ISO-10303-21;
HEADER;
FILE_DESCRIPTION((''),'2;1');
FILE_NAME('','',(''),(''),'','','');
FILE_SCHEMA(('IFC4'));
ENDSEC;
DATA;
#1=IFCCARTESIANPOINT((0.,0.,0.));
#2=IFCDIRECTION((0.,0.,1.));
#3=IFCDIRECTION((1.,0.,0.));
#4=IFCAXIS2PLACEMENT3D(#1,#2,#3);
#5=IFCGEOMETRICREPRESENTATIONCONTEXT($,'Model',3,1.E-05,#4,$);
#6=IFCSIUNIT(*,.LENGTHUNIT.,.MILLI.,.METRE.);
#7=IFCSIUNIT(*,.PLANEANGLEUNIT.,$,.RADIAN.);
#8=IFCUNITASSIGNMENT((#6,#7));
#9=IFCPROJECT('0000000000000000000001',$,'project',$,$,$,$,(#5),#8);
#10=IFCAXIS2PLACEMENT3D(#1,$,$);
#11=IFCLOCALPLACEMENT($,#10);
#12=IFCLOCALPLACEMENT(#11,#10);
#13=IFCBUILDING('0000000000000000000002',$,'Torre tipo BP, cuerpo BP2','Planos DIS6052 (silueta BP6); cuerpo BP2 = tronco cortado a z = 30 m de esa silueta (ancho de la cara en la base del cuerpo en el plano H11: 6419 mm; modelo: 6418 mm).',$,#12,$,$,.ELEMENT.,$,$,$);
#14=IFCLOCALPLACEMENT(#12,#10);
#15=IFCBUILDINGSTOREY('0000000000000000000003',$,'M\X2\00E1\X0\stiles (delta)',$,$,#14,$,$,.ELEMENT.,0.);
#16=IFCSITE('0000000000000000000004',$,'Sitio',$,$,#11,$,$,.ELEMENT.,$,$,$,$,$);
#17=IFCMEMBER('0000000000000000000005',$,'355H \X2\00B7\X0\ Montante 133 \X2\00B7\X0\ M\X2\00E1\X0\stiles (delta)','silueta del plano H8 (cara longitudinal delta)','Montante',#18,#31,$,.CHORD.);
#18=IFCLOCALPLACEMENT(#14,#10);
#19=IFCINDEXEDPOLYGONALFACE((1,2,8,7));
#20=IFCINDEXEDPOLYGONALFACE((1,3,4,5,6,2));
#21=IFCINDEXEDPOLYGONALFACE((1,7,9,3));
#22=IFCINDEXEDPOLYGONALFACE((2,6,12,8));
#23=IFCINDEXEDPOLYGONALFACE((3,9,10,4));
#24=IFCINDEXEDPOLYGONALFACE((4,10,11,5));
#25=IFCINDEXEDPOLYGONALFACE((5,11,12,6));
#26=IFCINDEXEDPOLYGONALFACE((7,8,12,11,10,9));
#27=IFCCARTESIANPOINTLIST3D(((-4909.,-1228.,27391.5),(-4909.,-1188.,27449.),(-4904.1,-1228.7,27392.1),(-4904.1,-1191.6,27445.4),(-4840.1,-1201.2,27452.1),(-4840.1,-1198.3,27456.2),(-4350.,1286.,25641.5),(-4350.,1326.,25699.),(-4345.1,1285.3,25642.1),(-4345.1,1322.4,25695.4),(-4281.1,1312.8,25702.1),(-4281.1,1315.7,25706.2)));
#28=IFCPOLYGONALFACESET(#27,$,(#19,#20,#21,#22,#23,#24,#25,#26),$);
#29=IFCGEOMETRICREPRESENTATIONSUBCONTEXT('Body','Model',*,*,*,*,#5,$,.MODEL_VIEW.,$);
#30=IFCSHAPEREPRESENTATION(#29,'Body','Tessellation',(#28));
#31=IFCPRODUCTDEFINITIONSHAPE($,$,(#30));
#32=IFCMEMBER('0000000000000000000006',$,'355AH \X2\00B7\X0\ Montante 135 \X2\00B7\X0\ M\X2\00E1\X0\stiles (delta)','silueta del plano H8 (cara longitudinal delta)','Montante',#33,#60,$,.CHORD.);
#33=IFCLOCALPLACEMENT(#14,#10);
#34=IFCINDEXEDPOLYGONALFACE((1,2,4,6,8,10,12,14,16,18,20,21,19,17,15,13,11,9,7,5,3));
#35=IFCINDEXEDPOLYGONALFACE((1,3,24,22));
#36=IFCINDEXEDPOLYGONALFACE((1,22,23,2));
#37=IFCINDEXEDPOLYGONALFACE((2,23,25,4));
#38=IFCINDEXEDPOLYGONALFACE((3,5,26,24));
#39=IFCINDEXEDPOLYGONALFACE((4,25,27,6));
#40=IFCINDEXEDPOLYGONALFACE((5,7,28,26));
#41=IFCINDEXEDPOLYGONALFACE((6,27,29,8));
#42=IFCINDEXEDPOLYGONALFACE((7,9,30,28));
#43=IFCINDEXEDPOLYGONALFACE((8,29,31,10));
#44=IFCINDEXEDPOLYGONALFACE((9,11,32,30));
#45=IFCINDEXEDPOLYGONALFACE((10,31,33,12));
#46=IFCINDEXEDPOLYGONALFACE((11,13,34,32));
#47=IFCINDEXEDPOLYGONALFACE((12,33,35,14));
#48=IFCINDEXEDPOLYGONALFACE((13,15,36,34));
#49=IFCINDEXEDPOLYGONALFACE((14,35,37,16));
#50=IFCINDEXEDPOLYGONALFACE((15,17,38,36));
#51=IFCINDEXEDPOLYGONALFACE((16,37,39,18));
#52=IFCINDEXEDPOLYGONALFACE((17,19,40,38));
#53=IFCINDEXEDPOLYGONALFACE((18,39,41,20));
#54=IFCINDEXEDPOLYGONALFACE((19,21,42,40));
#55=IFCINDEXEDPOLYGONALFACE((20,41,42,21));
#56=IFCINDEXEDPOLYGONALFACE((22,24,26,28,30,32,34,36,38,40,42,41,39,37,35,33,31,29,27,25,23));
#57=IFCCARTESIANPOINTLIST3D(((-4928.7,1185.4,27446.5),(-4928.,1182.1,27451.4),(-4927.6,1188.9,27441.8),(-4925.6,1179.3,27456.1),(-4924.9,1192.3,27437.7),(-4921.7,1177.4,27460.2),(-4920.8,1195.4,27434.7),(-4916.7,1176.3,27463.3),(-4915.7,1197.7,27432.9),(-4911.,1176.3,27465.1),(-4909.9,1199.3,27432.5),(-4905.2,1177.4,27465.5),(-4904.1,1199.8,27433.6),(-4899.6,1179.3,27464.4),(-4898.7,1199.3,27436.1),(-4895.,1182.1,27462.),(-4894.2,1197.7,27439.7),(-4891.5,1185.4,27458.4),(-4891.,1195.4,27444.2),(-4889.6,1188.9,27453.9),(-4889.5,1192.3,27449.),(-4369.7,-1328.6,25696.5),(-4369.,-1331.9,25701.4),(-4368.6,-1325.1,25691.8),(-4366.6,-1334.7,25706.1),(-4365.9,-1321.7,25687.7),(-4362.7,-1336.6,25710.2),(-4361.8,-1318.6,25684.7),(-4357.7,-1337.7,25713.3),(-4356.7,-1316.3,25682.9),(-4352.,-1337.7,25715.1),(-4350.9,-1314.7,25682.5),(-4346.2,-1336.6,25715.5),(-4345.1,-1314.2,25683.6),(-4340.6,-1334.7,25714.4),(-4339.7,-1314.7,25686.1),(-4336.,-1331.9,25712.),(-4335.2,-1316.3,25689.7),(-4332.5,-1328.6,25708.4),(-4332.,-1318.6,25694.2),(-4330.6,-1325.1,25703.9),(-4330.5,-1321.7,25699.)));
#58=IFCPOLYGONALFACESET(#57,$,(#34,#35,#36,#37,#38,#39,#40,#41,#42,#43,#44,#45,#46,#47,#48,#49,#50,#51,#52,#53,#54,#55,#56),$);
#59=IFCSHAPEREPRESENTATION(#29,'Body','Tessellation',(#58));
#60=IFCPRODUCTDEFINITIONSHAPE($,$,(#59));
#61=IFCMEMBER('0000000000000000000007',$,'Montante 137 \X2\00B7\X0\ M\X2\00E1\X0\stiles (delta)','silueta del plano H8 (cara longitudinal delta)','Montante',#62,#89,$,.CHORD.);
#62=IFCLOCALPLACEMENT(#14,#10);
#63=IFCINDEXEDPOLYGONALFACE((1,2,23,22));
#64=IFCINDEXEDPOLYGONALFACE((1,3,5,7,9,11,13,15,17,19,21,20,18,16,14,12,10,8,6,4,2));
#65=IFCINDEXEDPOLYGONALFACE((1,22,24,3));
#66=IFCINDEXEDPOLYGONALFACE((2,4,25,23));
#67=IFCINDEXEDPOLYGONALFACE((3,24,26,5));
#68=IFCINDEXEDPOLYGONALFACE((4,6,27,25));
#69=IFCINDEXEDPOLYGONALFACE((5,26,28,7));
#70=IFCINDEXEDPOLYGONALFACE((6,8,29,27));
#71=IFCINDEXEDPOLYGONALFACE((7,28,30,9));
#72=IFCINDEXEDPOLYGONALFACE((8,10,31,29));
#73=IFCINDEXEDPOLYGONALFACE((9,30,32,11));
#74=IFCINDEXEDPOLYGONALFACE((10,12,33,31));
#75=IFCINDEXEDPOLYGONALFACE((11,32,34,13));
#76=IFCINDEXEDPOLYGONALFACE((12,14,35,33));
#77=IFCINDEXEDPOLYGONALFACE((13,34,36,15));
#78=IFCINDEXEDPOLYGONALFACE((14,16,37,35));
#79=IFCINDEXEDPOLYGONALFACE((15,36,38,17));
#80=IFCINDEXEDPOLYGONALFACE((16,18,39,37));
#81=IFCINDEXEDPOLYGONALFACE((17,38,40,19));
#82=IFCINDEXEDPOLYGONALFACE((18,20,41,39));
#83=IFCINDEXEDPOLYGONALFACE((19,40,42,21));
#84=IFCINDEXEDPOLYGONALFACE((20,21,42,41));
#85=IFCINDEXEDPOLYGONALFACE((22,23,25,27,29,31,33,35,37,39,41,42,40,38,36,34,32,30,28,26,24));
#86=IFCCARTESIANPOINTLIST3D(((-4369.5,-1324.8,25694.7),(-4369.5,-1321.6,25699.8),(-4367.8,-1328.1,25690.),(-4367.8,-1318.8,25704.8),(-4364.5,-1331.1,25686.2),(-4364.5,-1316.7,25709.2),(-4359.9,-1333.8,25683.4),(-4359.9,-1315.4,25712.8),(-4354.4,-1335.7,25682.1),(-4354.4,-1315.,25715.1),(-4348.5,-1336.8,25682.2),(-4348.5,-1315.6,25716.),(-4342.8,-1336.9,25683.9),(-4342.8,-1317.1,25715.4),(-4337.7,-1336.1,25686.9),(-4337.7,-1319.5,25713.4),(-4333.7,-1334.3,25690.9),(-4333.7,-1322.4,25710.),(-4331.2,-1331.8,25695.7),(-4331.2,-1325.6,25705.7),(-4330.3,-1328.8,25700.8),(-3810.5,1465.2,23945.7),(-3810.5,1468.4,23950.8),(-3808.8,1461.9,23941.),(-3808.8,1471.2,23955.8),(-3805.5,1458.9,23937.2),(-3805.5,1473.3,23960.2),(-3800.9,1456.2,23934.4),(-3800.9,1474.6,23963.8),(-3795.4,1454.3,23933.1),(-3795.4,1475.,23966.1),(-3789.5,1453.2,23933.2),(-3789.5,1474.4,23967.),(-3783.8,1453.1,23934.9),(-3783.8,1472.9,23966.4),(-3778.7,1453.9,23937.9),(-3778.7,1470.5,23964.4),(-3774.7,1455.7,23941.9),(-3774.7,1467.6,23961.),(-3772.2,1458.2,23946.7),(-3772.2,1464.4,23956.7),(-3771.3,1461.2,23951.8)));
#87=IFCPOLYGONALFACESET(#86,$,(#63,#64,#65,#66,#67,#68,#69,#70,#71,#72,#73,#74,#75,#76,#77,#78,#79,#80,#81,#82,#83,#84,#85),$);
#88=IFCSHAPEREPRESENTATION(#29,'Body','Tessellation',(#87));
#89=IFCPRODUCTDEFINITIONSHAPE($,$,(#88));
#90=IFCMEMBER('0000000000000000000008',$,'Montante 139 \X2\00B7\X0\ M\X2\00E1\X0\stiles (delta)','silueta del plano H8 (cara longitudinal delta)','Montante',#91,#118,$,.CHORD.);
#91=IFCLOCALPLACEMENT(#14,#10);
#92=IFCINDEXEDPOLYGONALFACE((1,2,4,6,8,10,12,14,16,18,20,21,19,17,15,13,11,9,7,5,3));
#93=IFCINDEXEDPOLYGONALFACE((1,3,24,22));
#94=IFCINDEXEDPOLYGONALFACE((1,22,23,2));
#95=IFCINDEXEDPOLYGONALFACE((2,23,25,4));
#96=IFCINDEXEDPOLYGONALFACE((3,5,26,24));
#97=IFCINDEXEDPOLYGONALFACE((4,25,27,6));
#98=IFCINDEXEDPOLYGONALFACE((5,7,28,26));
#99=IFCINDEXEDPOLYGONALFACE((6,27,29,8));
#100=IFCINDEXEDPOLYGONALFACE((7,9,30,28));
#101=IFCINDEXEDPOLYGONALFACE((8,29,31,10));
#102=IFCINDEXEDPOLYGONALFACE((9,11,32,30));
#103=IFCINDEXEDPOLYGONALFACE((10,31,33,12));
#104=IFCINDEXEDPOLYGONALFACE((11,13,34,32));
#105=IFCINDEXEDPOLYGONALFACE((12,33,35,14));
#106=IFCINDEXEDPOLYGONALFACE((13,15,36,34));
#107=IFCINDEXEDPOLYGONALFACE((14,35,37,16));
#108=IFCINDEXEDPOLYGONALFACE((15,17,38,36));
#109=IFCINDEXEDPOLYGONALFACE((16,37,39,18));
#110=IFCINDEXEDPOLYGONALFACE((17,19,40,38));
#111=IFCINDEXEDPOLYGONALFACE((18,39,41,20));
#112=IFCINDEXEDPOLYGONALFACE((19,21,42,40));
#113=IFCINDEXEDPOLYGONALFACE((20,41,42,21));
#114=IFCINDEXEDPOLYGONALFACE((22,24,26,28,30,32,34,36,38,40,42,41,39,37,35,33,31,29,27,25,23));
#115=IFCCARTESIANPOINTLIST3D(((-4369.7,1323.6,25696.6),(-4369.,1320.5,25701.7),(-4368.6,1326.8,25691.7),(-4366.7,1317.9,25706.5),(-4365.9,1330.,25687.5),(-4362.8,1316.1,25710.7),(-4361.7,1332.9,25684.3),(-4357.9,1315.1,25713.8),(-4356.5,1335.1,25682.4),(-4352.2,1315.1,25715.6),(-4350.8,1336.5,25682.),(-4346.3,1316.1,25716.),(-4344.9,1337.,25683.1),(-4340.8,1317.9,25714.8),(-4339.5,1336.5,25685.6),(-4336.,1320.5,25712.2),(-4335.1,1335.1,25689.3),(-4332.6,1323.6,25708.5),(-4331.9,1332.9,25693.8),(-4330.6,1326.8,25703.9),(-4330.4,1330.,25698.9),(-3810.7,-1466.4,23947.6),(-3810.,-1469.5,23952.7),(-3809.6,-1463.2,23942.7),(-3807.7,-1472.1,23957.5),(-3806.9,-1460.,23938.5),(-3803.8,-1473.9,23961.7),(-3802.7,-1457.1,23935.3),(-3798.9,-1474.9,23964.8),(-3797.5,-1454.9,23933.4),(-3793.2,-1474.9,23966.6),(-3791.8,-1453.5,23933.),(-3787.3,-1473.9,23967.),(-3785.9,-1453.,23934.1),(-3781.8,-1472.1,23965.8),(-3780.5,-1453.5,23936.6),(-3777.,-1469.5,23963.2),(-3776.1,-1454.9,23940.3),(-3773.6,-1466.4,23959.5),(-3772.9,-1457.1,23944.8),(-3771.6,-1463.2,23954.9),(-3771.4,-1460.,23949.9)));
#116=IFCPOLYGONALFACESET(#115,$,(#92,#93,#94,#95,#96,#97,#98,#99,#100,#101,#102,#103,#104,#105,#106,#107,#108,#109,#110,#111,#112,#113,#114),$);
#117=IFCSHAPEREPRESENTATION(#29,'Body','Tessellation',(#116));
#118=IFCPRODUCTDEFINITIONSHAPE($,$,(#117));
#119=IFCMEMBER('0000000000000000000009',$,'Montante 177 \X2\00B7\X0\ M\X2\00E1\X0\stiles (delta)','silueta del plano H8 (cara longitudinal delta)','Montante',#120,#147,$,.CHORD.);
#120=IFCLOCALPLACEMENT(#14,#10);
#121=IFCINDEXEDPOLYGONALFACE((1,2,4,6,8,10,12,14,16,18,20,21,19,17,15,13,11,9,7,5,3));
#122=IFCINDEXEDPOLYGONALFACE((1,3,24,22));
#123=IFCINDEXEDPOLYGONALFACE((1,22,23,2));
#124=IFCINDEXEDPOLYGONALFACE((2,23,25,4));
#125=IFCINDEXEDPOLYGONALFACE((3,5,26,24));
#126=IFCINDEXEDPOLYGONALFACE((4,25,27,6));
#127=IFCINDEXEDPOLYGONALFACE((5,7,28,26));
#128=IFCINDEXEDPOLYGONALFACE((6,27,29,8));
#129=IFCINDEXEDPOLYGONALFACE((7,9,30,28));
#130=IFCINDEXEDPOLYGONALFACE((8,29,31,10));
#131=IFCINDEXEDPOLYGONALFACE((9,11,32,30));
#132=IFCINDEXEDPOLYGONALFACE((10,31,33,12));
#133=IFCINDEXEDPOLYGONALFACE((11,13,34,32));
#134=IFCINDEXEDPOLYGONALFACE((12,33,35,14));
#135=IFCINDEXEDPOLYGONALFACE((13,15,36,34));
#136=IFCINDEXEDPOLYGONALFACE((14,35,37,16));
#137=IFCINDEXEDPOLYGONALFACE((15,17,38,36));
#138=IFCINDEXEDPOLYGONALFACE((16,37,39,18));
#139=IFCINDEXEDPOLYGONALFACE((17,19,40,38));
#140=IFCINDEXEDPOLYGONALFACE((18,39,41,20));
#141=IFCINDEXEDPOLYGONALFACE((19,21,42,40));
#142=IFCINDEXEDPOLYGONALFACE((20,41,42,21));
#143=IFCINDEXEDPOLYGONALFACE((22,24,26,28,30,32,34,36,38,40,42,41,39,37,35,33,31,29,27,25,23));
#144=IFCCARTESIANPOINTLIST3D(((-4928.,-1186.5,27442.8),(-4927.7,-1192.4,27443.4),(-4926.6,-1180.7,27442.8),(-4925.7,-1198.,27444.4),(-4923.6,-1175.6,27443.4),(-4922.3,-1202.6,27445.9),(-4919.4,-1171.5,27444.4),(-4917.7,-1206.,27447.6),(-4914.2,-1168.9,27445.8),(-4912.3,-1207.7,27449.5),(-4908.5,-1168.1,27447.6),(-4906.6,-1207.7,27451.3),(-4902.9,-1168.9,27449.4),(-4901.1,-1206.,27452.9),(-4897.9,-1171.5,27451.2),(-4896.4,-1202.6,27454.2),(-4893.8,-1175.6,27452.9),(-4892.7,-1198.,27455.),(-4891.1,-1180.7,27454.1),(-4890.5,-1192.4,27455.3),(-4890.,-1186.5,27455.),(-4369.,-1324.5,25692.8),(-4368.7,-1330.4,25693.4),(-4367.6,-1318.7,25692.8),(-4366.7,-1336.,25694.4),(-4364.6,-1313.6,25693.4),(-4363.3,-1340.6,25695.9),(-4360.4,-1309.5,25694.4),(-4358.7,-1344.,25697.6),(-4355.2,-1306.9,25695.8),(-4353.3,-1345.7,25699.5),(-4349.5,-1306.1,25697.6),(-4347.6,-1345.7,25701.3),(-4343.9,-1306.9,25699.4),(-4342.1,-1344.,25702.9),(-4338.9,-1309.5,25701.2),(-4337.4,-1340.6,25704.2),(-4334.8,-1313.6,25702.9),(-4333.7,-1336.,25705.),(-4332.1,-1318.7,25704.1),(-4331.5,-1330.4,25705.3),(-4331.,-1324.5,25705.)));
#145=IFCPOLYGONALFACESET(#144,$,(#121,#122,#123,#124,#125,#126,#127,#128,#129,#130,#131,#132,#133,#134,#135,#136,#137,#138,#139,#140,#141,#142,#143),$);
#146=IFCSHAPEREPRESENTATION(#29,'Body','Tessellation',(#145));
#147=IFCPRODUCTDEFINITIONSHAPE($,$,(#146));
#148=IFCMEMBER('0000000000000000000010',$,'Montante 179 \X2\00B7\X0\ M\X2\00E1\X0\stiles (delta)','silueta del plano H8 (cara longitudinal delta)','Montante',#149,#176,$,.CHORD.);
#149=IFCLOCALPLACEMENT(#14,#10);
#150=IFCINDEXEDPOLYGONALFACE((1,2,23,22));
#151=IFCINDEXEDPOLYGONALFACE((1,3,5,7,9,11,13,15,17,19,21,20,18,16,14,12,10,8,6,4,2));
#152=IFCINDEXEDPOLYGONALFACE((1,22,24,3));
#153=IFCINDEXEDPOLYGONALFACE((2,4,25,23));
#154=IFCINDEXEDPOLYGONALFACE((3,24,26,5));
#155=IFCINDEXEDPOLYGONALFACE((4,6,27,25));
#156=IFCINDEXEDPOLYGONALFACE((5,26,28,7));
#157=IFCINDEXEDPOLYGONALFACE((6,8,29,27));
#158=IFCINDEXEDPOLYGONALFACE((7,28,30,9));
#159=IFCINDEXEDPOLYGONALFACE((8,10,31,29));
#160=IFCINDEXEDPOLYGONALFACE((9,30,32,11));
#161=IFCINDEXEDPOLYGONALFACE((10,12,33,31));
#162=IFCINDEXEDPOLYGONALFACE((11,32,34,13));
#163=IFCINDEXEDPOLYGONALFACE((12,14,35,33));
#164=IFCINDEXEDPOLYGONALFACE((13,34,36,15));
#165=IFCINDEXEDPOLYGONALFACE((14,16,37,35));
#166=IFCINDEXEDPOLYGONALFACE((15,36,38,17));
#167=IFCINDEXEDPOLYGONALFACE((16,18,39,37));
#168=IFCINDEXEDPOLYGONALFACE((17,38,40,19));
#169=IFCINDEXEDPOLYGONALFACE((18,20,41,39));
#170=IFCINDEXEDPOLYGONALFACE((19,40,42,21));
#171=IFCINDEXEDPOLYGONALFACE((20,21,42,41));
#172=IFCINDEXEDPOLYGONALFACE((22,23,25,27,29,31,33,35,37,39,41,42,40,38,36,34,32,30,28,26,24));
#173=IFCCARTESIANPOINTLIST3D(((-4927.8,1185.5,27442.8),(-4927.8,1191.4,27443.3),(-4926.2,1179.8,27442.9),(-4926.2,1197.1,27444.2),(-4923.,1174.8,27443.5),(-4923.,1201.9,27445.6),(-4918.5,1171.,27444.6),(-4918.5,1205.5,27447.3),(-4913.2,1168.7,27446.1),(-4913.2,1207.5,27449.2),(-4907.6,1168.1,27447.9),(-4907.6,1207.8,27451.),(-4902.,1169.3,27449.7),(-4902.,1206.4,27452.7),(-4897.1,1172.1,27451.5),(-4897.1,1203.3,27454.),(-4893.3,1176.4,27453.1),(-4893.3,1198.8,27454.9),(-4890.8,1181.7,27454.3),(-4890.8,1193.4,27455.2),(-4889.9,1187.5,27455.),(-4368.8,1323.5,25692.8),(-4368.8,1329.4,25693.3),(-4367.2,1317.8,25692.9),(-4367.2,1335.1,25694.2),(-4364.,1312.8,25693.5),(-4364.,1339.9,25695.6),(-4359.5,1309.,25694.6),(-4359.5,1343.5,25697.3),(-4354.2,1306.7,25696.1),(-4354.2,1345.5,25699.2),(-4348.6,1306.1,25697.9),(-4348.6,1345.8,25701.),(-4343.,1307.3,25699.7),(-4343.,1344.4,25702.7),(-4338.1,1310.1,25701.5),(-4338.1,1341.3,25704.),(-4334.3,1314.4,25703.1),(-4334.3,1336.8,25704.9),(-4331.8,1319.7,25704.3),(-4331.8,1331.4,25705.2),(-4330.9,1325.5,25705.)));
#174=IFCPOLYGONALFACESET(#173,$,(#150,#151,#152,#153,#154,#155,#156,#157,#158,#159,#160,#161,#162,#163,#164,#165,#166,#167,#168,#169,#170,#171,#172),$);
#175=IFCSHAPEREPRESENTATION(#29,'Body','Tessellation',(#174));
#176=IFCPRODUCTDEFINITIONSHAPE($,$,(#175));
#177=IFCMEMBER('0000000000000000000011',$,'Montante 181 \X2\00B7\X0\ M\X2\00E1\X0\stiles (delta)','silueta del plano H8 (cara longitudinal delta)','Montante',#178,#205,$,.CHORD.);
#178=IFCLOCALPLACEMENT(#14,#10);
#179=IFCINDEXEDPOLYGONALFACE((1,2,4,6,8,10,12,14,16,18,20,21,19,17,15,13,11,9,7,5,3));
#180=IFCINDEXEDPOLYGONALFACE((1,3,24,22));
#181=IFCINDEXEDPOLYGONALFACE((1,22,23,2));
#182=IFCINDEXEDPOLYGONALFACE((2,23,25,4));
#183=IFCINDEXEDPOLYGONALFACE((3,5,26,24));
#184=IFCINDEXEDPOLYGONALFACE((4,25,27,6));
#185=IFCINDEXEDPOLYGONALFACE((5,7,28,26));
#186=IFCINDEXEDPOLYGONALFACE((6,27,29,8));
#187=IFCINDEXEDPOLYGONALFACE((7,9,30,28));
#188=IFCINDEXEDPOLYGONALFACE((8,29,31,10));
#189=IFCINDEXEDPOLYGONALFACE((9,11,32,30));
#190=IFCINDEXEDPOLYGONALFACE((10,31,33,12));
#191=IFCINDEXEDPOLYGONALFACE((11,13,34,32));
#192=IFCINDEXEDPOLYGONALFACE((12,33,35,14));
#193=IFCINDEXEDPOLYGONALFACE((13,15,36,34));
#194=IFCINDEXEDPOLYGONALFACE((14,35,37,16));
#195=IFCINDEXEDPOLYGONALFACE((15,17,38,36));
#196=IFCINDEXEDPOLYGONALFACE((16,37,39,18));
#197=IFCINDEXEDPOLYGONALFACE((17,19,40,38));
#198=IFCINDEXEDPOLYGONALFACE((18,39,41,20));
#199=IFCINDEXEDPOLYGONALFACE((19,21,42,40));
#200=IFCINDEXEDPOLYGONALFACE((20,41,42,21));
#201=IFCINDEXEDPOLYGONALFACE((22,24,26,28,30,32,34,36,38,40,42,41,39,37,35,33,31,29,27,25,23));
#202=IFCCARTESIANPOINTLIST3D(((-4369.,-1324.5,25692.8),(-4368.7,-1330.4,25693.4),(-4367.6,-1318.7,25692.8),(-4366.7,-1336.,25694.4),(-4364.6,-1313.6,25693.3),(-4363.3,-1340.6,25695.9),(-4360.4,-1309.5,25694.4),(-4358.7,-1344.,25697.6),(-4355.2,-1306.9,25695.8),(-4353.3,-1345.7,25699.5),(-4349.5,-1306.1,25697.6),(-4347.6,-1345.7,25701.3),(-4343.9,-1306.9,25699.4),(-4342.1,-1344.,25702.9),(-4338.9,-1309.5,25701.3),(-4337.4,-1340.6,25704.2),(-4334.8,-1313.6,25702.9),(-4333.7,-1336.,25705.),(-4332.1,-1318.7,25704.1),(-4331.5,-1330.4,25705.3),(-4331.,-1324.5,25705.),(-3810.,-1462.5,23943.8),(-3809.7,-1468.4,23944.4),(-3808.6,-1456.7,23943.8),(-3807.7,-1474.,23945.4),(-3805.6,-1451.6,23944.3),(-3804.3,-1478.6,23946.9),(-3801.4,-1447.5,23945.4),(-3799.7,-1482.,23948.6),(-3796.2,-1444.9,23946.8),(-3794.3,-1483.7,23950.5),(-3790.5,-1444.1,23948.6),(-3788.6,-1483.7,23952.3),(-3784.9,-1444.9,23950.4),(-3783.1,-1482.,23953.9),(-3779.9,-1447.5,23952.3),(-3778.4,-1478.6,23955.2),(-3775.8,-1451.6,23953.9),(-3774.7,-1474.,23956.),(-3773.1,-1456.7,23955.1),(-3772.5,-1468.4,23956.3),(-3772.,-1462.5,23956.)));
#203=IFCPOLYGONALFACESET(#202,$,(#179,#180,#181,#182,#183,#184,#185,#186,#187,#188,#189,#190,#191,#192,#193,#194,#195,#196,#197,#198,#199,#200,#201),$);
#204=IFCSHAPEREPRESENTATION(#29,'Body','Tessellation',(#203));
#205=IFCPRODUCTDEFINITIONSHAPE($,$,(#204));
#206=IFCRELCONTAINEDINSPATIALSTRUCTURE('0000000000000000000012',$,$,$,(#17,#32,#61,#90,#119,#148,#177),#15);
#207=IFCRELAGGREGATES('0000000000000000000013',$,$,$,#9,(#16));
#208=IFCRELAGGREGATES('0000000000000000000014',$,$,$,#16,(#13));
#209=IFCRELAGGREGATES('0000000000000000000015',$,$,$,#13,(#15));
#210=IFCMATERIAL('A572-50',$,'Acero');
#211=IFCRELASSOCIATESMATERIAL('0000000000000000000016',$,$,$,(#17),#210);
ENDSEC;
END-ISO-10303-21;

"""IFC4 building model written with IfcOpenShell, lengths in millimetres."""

from ifc_helpers import new_model, si_unit, frame, frame_2d, origin, origin_with_axes, place, context, subcontext, project, spatial, circle, l_section, extrude, material, element, save


model = new_model("IFC4")

# Units and contexts
model_context = context("Model", 3, precision=1e-05, world=origin_with_axes())
body_context = subcontext(model_context, "Body", "Model", "MODEL_VIEW")
ifc_project = project(units=[si_unit("LENGTHUNIT", "METRE", prefix="MILLI"), si_unit("PLANEANGLEUNIT", "RADIAN")], contexts=[model_context])

# Site, building, storey
site_placement = place(None, origin())
site = spatial("IfcSite", under=ifc_project, at=site_placement, Name="Sitio", CompositionType="ELEMENT")
building_placement = place(site_placement, origin())
building = spatial("IfcBuilding", under=site, at=building_placement, Name="Torre tipo BP, cuerpo BP2", Description="Planos DIS6052 (silueta BP6); cuerpo BP2 = tronco cortado a z = 30 m de esa silueta (ancho de la cara en la base del cuerpo en el plano H11: 6419 mm; modelo: 6418 mm).", CompositionType="ELEMENT")
storey_placement = place(building_placement, origin())
storey = spatial("IfcBuildingStorey", under=building, at=storey_placement, Name="Mástiles (delta)", CompositionType="ELEMENT", Elevation=0.0)

# Members
ifc_material = material(Name="A572-50", Category="Acero")
member_1_placement = place(storey_placement, frame((-4909.0, -1188.0, 27449.0), z_axis=(0.179529, 0.807398, -0.562031), x_axis=(0.983753, -0.147345, 0.102567)))
element("IfcMember", 1, at=member_1_placement, inside=storey, material=ifc_material, Name="355H · Montante 133 · Mástiles (delta)", Description="silueta del plano H8 (cara longitudinal delta)", ObjectType="Montante", PredefinedType="CHORD", context=body_context, shape_type="SweptSolid", body=[
    extrude(l_section(Depth=70.0, Width=70.0, Thickness=5.0, at=frame_2d((35.0, 35.0))), None, (0.0, 0.0, 1.0), 3113.7),
])
member_2_placement = place(storey_placement, frame((-4909.0, 1188.0, 27449.0), z_axis=(0.179529, -0.807398, -0.562031), x_axis=(0.245676, 0.590008, -0.769112)))
element("IfcMember", 2, at=member_2_placement, inside=storey, Name="355AH · Montante 135 · Mástiles (delta)", Description="silueta del plano H8 (cara longitudinal delta)", ObjectType="Montante", PredefinedType="CHORD", context=body_context, shape_type="SweptSolid", body=[
    extrude(circle(Radius=20.0), None, (0.0, 0.0, 1.0), 3113.7),
])
for number, where, z_axis, x_axis, name in (
    (3, (-4350.0, -1326.0, 25699.0), (0.167365, 0.83533, -0.523653), (0.985895, -0.141806, 0.088895), "Montante 137 · Mástiles (delta)"),
    (4, (-4350.0, 1326.0, 25699.0), (0.167365, -0.83533, -0.523653), (0.254308, 0.549749, -0.795678), "Montante 139 · Mástiles (delta)"),
):
    element("IfcMember", number, at=place(storey_placement, frame(where, z_axis=z_axis, x_axis=x_axis)), inside=storey, Name=name, Description="silueta del plano H8 (cara longitudinal delta)", ObjectType="Montante", PredefinedType="CHORD", context=body_context, shape_type="SweptSolid", body=[
        extrude(circle(Radius=20.0), None, (0.0, 0.0, 1.0), 3340.0),
    ])
for number, where, z_axis, x_axis, name in (
    (5, (-4909.0, -1188.0, 27449.0), (0.303427, -0.074907, -0.949906), (0.022793, 0.997191, -0.071355), "Montante 177 · Mástiles (delta)"),
    (6, (-4909.0, 1188.0, 27449.0), (0.303427, 0.074907, -0.949906), (0.952855, -0.023853, 0.302488), "Montante 179 · Mástiles (delta)"),
):
    element("IfcMember", number, at=place(storey_placement, frame(where, z_axis=z_axis, x_axis=x_axis)), inside=storey, Name=name, Description="silueta del plano H8 (cara longitudinal delta)", ObjectType="Montante", PredefinedType="CHORD", context=body_context, shape_type="SweptSolid", body=[
        extrude(circle(Radius=20.0), None, (0.0, 0.0, 1.0), 1842.3),
    ])
for number, where, z_axis, x_axis, name in (
    (7, (-4350.0, -1326.0, 25699.0), (0.303584, -0.074945, -0.949853), (0.022816, 0.997188, -0.071388), "Montante 181 · Mástiles (delta)"),
):
    element("IfcMember", number, at=place(storey_placement, frame(where, z_axis=z_axis, x_axis=x_axis)), inside=storey, Name=name, Description="silueta del plano H8 (cara longitudinal delta)", ObjectType="Montante", PredefinedType="CHORD", context=body_context, shape_type="SweptSolid", body=[
        extrude(circle(Radius=20.0), None, (0.0, 0.0, 1.0), 1841.3),
    ])

save(model, "model.ifc")
